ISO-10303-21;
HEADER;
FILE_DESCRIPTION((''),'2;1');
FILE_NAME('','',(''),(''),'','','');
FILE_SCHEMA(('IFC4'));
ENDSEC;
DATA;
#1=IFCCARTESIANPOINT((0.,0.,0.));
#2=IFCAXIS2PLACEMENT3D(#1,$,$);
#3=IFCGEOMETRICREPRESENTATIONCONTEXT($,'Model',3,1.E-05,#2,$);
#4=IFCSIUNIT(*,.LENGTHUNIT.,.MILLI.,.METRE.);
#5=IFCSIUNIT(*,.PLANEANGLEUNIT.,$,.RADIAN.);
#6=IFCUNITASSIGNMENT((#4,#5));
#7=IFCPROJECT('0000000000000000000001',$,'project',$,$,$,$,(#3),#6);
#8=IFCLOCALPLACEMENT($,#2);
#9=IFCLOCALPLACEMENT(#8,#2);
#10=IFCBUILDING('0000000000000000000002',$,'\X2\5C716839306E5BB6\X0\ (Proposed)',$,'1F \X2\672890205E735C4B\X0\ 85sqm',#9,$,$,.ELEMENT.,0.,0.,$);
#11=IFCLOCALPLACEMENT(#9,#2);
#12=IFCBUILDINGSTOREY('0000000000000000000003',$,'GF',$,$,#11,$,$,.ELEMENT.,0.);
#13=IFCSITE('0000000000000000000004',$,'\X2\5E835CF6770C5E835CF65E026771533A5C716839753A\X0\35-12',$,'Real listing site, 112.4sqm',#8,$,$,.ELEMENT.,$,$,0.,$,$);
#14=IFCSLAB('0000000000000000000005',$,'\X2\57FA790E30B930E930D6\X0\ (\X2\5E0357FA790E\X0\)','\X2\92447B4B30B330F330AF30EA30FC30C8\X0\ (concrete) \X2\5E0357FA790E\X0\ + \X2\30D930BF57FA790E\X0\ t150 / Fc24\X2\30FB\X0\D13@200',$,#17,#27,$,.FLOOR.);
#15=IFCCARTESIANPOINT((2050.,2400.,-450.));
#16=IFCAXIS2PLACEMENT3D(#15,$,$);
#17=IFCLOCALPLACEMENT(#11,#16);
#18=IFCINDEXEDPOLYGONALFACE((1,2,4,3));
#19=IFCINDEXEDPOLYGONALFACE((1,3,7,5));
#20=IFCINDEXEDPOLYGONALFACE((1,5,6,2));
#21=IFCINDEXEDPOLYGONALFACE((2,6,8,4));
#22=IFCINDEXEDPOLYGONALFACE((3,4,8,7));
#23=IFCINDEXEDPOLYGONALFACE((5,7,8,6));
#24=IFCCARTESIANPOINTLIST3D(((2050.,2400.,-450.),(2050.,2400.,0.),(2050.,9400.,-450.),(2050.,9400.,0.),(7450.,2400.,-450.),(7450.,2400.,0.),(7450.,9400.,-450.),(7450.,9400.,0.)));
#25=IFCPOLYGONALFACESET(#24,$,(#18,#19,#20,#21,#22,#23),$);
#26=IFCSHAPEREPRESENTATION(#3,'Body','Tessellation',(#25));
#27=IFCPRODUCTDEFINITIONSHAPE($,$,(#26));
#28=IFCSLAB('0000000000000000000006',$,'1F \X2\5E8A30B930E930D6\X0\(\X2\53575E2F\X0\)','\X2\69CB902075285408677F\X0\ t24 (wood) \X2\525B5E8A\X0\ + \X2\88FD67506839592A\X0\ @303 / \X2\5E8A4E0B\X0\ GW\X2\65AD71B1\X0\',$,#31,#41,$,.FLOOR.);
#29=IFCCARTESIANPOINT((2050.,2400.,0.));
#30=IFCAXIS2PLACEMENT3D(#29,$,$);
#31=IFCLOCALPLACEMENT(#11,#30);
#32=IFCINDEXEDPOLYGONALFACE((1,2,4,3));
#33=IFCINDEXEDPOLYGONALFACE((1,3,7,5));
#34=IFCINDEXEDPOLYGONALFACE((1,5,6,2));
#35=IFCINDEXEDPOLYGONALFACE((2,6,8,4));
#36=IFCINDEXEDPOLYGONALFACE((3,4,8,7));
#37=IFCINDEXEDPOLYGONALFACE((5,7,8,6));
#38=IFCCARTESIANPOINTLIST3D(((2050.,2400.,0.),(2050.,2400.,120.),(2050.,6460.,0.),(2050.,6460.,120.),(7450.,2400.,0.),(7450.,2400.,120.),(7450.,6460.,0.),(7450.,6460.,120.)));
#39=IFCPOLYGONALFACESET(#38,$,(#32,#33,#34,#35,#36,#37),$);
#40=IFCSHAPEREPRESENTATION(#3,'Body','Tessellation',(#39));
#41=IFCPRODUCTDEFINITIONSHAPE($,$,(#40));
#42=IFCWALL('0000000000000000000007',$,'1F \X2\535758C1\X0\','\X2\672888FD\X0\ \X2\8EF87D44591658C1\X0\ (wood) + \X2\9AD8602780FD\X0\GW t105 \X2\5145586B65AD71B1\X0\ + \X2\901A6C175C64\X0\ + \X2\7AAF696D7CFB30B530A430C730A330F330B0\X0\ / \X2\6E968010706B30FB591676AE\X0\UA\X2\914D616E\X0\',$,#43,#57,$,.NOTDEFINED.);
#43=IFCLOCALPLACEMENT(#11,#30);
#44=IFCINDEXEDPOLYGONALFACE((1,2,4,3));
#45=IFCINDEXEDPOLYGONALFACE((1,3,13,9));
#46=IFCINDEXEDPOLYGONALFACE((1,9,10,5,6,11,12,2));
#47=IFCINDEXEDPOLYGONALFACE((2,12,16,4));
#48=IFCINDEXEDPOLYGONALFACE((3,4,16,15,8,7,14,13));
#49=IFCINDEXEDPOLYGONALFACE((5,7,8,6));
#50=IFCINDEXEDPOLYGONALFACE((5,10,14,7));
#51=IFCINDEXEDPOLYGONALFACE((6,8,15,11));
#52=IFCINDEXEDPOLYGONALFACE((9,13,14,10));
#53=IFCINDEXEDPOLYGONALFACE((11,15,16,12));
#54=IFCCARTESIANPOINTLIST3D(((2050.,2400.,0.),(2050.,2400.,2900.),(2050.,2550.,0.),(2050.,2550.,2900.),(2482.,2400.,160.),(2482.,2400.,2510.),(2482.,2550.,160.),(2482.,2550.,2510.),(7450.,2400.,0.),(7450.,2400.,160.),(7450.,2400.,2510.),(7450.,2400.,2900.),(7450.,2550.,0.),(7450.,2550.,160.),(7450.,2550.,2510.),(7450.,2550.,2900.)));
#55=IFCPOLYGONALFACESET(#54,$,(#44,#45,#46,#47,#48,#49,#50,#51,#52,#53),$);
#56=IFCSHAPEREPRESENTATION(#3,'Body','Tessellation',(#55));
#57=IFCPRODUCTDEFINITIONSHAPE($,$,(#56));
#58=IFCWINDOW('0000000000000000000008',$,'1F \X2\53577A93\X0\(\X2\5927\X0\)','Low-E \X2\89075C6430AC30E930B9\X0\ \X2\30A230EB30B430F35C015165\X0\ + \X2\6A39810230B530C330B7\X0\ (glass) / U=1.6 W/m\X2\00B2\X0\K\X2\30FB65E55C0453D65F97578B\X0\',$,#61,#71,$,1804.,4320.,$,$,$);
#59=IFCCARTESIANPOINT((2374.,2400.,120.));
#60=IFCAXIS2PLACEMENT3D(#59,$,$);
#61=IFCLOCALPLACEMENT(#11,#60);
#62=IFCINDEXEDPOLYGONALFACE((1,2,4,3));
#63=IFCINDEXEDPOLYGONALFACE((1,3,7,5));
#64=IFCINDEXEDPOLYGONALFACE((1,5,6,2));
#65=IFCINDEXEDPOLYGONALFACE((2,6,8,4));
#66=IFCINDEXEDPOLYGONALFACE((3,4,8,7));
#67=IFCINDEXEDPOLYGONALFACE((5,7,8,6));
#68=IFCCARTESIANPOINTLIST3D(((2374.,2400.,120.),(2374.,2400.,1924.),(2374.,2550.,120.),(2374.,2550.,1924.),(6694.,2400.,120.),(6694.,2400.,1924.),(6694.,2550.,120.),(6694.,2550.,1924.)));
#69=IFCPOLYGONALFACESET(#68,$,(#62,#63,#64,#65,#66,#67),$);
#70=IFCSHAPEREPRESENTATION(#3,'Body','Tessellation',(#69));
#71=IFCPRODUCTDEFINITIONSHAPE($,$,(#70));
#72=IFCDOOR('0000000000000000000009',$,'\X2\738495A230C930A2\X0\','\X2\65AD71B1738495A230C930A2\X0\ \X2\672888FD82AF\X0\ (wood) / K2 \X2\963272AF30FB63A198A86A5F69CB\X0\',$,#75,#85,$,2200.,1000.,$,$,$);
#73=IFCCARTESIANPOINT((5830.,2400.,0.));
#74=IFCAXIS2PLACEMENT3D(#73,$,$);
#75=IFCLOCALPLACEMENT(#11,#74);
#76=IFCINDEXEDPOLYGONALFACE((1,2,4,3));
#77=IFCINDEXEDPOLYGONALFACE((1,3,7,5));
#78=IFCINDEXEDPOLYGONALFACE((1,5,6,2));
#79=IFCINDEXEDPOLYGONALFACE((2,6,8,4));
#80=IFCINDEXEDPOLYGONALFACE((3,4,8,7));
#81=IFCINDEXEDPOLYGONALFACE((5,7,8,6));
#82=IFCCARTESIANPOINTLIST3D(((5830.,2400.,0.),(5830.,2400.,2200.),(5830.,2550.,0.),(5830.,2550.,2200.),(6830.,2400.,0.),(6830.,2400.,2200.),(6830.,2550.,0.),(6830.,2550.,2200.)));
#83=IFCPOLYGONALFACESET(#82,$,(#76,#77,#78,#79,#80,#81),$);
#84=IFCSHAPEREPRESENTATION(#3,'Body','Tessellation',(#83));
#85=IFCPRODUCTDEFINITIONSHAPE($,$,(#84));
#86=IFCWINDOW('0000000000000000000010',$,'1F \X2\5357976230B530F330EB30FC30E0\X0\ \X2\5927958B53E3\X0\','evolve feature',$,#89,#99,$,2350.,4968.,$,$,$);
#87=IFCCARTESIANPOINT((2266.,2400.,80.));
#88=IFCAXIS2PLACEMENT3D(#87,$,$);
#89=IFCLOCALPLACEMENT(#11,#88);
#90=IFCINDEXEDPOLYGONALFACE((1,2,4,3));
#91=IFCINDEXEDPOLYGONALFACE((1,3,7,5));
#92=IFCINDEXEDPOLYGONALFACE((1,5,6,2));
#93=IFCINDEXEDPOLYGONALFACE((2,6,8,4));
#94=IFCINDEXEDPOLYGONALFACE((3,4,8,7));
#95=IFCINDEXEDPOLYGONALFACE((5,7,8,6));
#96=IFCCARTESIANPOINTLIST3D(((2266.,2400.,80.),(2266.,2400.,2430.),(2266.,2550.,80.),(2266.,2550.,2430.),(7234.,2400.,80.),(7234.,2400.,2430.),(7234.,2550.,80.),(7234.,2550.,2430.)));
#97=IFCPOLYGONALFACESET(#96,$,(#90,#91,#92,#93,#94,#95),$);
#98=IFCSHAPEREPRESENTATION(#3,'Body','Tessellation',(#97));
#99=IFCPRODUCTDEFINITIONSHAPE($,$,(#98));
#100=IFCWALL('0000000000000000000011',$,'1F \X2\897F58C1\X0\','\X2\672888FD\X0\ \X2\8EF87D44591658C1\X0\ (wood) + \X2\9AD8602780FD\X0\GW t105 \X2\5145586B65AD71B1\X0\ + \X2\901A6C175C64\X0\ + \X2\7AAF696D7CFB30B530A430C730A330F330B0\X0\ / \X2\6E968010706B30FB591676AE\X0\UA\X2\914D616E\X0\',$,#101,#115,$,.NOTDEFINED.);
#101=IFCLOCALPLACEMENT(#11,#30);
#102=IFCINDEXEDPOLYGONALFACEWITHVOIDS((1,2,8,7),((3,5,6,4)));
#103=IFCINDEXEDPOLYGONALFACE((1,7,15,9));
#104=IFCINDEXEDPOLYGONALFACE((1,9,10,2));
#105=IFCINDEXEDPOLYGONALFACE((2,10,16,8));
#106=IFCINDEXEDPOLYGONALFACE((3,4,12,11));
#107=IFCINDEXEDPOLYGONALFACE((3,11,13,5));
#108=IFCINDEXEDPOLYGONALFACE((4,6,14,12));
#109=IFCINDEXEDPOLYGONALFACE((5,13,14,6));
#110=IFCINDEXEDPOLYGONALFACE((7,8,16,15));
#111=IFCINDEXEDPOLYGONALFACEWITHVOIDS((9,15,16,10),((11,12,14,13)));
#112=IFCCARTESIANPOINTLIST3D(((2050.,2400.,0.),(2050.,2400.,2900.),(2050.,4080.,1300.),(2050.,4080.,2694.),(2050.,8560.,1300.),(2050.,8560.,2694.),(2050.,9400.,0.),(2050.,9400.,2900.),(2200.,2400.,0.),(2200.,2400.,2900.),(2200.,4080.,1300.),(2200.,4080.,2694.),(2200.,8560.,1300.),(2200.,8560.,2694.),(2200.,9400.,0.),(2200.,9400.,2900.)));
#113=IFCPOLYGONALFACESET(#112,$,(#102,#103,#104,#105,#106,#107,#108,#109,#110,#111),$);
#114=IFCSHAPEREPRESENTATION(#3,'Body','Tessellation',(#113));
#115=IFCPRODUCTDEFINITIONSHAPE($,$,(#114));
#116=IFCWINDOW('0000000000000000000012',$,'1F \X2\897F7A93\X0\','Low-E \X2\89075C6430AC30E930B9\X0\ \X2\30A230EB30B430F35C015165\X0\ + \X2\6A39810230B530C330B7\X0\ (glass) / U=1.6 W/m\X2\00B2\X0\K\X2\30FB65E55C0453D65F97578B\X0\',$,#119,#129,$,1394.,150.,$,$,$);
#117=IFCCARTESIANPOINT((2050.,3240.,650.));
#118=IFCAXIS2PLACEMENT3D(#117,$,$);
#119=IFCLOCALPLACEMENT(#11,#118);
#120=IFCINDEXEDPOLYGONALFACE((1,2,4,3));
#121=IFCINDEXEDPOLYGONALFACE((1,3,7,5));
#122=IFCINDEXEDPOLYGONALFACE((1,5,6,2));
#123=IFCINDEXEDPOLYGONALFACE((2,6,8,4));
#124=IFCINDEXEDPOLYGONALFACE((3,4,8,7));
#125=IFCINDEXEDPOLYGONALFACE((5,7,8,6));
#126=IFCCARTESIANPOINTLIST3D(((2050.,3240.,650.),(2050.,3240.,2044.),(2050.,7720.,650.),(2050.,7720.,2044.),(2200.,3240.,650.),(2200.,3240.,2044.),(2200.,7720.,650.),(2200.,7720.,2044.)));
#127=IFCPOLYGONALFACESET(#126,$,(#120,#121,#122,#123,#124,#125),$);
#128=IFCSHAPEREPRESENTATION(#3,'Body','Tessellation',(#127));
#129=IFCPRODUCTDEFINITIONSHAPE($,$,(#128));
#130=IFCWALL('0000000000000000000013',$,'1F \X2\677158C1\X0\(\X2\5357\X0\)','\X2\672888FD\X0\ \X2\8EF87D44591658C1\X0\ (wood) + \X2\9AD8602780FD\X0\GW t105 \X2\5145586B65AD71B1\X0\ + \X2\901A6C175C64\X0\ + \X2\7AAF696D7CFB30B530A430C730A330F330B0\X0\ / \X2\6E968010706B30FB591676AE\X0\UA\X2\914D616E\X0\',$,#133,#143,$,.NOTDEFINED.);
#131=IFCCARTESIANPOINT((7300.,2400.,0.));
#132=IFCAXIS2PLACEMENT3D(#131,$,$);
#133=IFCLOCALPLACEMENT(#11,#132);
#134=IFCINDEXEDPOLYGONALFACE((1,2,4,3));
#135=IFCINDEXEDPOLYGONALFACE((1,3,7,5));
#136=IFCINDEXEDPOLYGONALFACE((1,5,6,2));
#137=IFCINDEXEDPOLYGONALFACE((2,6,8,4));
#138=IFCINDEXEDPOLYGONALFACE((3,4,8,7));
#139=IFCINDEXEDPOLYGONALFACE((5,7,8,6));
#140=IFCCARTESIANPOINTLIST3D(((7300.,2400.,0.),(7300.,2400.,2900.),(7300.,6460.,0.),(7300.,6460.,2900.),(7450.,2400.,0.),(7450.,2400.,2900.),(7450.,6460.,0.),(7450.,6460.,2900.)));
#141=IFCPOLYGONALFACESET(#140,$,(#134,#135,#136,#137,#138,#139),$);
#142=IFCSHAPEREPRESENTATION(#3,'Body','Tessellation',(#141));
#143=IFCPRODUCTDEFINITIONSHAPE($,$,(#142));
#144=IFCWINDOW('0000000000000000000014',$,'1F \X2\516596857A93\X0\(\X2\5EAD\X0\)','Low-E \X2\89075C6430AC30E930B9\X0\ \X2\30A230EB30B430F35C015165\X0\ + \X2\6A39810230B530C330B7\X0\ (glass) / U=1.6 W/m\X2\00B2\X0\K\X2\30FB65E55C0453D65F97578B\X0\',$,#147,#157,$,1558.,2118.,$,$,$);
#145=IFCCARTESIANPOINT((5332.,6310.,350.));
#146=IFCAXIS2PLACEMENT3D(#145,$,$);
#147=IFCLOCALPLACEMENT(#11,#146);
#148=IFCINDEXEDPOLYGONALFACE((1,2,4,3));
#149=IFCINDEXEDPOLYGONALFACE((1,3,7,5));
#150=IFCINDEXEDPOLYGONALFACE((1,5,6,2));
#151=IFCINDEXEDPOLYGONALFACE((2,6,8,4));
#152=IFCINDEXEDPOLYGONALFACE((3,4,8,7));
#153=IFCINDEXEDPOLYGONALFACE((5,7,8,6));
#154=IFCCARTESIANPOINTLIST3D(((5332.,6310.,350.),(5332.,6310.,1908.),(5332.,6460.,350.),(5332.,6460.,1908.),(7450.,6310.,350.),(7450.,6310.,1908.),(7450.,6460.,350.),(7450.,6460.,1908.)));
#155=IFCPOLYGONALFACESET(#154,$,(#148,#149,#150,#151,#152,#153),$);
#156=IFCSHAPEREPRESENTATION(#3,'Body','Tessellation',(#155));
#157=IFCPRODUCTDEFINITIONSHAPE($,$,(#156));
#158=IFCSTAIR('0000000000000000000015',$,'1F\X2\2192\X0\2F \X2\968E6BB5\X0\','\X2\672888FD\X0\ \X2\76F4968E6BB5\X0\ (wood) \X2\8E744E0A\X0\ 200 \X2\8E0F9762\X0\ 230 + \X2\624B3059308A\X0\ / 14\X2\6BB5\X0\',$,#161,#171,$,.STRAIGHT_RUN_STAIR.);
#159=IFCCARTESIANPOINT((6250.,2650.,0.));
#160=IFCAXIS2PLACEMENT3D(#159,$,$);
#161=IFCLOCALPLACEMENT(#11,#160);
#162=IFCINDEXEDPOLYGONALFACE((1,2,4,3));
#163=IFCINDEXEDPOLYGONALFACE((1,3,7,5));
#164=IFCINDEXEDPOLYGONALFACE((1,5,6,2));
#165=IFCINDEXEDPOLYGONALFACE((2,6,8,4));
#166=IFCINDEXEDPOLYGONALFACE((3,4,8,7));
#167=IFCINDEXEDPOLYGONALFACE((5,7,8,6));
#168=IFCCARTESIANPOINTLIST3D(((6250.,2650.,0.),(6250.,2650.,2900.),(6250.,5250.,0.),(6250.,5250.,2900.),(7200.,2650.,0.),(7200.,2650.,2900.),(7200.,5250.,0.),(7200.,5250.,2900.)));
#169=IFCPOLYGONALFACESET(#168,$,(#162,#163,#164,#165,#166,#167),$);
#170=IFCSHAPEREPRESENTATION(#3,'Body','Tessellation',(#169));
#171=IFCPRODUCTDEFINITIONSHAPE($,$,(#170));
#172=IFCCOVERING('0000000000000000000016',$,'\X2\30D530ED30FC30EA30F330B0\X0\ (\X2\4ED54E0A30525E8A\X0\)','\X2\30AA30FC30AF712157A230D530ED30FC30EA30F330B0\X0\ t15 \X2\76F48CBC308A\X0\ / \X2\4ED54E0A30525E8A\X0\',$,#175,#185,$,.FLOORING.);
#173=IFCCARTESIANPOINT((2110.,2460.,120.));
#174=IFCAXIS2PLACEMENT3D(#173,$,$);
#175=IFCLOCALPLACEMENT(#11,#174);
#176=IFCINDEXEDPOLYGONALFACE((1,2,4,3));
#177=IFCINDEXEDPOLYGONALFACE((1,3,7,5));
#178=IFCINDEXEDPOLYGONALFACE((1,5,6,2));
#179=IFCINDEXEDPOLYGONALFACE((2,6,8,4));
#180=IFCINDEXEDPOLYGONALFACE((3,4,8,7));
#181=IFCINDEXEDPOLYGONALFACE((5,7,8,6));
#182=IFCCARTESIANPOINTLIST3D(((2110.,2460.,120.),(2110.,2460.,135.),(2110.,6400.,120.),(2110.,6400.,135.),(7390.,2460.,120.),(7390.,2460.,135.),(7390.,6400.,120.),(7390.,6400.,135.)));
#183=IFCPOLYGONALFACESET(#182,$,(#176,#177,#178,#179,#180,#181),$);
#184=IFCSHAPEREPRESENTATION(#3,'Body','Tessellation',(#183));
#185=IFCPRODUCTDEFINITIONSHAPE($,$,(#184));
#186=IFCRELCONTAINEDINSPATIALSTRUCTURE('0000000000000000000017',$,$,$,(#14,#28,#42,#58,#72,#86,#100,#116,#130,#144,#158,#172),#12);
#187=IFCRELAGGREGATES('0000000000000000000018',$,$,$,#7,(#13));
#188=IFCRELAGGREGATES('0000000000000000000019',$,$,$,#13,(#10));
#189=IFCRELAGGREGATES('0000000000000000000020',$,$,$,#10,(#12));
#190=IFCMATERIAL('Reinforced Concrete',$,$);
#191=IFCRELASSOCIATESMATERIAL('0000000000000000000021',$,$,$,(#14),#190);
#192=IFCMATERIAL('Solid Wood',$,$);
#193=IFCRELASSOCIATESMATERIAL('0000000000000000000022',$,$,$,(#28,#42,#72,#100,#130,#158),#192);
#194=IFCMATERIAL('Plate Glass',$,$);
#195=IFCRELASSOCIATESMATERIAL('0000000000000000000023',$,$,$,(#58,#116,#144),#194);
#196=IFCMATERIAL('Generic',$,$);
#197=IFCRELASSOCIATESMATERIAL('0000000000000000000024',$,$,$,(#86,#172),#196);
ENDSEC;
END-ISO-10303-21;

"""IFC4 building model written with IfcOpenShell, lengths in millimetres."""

from ifc_helpers import new_model, si_unit, frame, frame_2d, origin, place, context, project, spatial, rectangle, extrude, material, element, fill, save


model = new_model("IFC4")

# Units and contexts
model_context = context("Model", 3, precision=1e-05, world=origin())
ifc_project = project(units=[si_unit("LENGTHUNIT", "METRE", prefix="MILLI"), si_unit("PLANEANGLEUNIT", "RADIAN")], contexts=[model_context])

# Site, building, storey
site_placement = place(None, origin())
site = spatial("IfcSite", under=ifc_project, at=site_placement, Name="広島県広島市東区山根町35-12", ObjectType="Real listing site, 112.4sqm", CompositionType="ELEMENT", RefElevation=0.0)
building_placement = place(site_placement, origin())
building = spatial("IfcBuilding", under=site, at=building_placement, Name="山根の家 (Proposed)", ObjectType="1F 木造平屋 85sqm", CompositionType="ELEMENT", ElevationOfRefHeight=0.0, ElevationOfTerrain=0.0)
storey_placement = place(building_placement, origin())
storey = spatial("IfcBuildingStorey", under=building, at=storey_placement, Name="GF", CompositionType="ELEMENT", Elevation=0.0)

# Slabs
ifc_material_1 = material(Name="Reinforced Concrete")
slab_1_placement = place(storey_placement, frame((2050.0, 2400.0, -450.0)))
element("IfcSlab", 1, at=slab_1_placement, inside=storey, material=ifc_material_1, Name="基礎スラブ (布基礎)", Description="鉄筋コンクリート (concrete) 布基礎 + ベタ基礎 t150 / Fc24・D13@200", PredefinedType="FLOOR", context=model_context, shape_type="SweptSolid", body=[
    extrude(rectangle(XDim=5400.0, YDim=7000.0, at=frame_2d((2700.0, 3500.0))), frame((2050.0, 2400.0, -450.0)), (0.0, 0.0, 1.0), 450.0),
])
ifc_material_2 = material(Name="Solid Wood")
slab_2_placement = place(storey_placement, frame((2050.0, 2400.0, 0.0)))
element("IfcSlab", 2, at=slab_2_placement, inside=storey, material=ifc_material_2, Name="1F 床スラブ(南帯)", Description="構造用合板 t24 (wood) 剛床 + 製材根太 @303 / 床下 GW断熱", PredefinedType="FLOOR", context=model_context, shape_type="SweptSolid", body=[
    extrude(rectangle(XDim=5400.0, YDim=4060.0, at=frame_2d((2700.0, 2030.0))), frame((2050.0, 2400.0, 0.0)), (0.0, 0.0, 1.0), 120.0),
])

# Wall, openings, windows, door
wall_1_placement = place(storey_placement, frame((2050.0, 2400.0, 0.0)))
wall_1 = element("IfcWall", 3, at=wall_1_placement, inside=storey, material=ifc_material_2, Name="1F 南壁", Description="木製 軸組外壁 (wood) + 高性能GW t105 充填断熱 + 通気層 + 窯業系サイディング / 準耐火・外皮UA配慮", PredefinedType="NOTDEFINED", context=model_context, shape_type="SweptSolid", body=[
    extrude(rectangle(XDim=5400.0, YDim=150.0, at=frame_2d((2700.0, 75.0))), frame((2050.0, 2400.0, 0.0)), (0.0, 0.0, 1.0), 2900.0),
])
opening_1_placement = place(storey_placement, frame((2374.0, 2400.0, 120.0)))
opening_1 = element("IfcOpeningElement", 4, at=opening_1_placement, cuts=wall_1, PredefinedType="NOTDEFINED", context=model_context, shape_type="SweptSolid", body=[
    extrude(rectangle(XDim=4320.0, YDim=150.0, at=frame_2d((2160.0, 75.0))), frame((2374.0, 2400.0, 120.0)), (0.0, 0.0, 1.0), 1804.0),
])
opening_2_placement = place(storey_placement, frame((5830.0, 2400.0, 0.0)))
opening_2 = element("IfcOpeningElement", 5, at=opening_2_placement, cuts=wall_1, PredefinedType="NOTDEFINED", context=model_context, shape_type="SweptSolid", body=[
    extrude(rectangle(XDim=1000.0, YDim=150.0, at=frame_2d((500.0, 75.0))), frame((5830.0, 2400.0, 0.0)), (0.0, 0.0, 1.0), 2200.0),
])
opening_3_placement = place(storey_placement, frame((2266.0, 2400.0, 80.0)))
opening_3 = element("IfcOpeningElement", 6, at=opening_3_placement, cuts=wall_1, PredefinedType="NOTDEFINED", context=model_context, shape_type="SweptSolid", body=[
    extrude(rectangle(XDim=4968.0, YDim=150.0, at=frame_2d((2484.0, 75.0))), frame((2266.0, 2400.0, 80.0)), (0.0, 0.0, 1.0), 2350.0),
])
ifc_material_3 = material(Name="Plate Glass")
window_1_placement = place(storey_placement, frame((2374.0, 2400.0, 120.0)))
window_1 = element("IfcWindow", 7, at=window_1_placement, inside=storey, material=ifc_material_3, Name="1F 南窓(大)", Description="Low-E 複層ガラス アルゴン封入 + 樹脂サッシ (glass) / U=1.6 W/m²K・日射取得型", OverallHeight=1804.0, OverallWidth=4320.0, context=model_context, shape_type="SweptSolid", body=[
    extrude(rectangle(XDim=4320.0, YDim=150.0, at=frame_2d((2160.0, 75.0))), frame((2374.0, 2400.0, 120.0)), (0.0, 0.0, 1.0), 1804.0),
])
fill(opening_1, window_1)
door_1_placement = place(storey_placement, frame((5830.0, 2400.0, 0.0)))
door_1 = element("IfcDoor", 8, at=door_1_placement, inside=storey, material=ifc_material_2, Name="玄関ドア", Description="断熱玄関ドア 木製芯 (wood) / K2 防犯・採風機構", OverallHeight=2200.0, OverallWidth=1000.0, context=model_context, shape_type="SweptSolid", body=[
    extrude(rectangle(XDim=1000.0, YDim=150.0, at=frame_2d((500.0, 75.0))), frame((5830.0, 2400.0, 0.0)), (0.0, 0.0, 1.0), 2200.0),
])
fill(opening_2, door_1)
ifc_material_4 = material(Name="Generic")
window_2_placement = place(storey_placement, frame((2266.0, 2400.0, 80.0)))
window_2 = element("IfcWindow", 9, at=window_2_placement, inside=storey, material=ifc_material_4, Name="1F 南面サンルーム 大開口", Description="evolve feature", OverallHeight=2350.0, OverallWidth=4968.0, context=model_context, shape_type="SweptSolid", body=[
    extrude(rectangle(XDim=4968.0, YDim=150.0, at=frame_2d((2484.0, 75.0))), frame((2266.0, 2400.0, 80.0)), (0.0, 0.0, 1.0), 2350.0),
])
fill(opening_3, window_2)

# Walls, openings, windows
wall_2_placement = place(storey_placement, frame((2050.0, 2400.0, 0.0)))
wall_2 = element("IfcWall", 10, at=wall_2_placement, inside=storey, material=ifc_material_2, Name="1F 西壁", Description="木製 軸組外壁 (wood) + 高性能GW t105 充填断熱 + 通気層 + 窯業系サイディング / 準耐火・外皮UA配慮", PredefinedType="NOTDEFINED", context=model_context, shape_type="SweptSolid", body=[
    extrude(rectangle(XDim=150.0, YDim=7000.0, at=frame_2d((75.0, 3500.0))), frame((2050.0, 2400.0, 0.0)), (0.0, 0.0, 1.0), 2900.0),
])
opening_4_placement = place(storey_placement, frame((2050.0, 3240.0, 650.0)))
opening_4 = element("IfcOpeningElement", 11, at=opening_4_placement, cuts=wall_2, PredefinedType="NOTDEFINED", context=model_context, shape_type="SweptSolid", body=[
    extrude(rectangle(XDim=150.0, YDim=4480.0, at=frame_2d((75.0, 2240.0))), frame((2050.0, 3240.0, 650.0)), (0.0, 0.0, 1.0), 1394.0),
])
window_3_placement = place(storey_placement, frame((2050.0, 3240.0, 650.0)))
window_3 = element("IfcWindow", 12, at=window_3_placement, inside=storey, material=ifc_material_3, Name="1F 西窓", Description="Low-E 複層ガラス アルゴン封入 + 樹脂サッシ (glass) / U=1.6 W/m²K・日射取得型", OverallHeight=1394.0, OverallWidth=150.0, context=model_context, shape_type="SweptSolid", body=[
    extrude(rectangle(XDim=150.0, YDim=4480.0, at=frame_2d((75.0, 2240.0))), frame((2050.0, 3240.0, 650.0)), (0.0, 0.0, 1.0), 1394.0),
])
fill(opening_4, window_3)
wall_3_placement = place(storey_placement, frame((7300.0, 2400.0, 0.0)))
wall_3 = element("IfcWall", 13, at=wall_3_placement, inside=storey, material=ifc_material_2, Name="1F 東壁(南)", Description="木製 軸組外壁 (wood) + 高性能GW t105 充填断熱 + 通気層 + 窯業系サイディング / 準耐火・外皮UA配慮", PredefinedType="NOTDEFINED", context=model_context, shape_type="SweptSolid", body=[
    extrude(rectangle(XDim=150.0, YDim=4060.0, at=frame_2d((75.0, 2030.0))), frame((7300.0, 2400.0, 0.0)), (0.0, 0.0, 1.0), 2900.0),
])
opening_5_placement = place(storey_placement, frame((5332.0, 6310.0, 350.0)))
opening_5 = element("IfcOpeningElement", 14, at=opening_5_placement, cuts=wall_3, PredefinedType="NOTDEFINED", context=model_context, shape_type="SweptSolid", body=[
    extrude(rectangle(XDim=2118.0, YDim=150.0, at=frame_2d((1059.0, 75.0))), frame((5332.0, 6310.0, 350.0)), (0.0, 0.0, 1.0), 1558.0),
])
window_4_placement = place(storey_placement, frame((5332.0, 6310.0, 350.0)))
window_4 = element("IfcWindow", 15, at=window_4_placement, inside=storey, material=ifc_material_3, Name="1F 入隅窓(庭)", Description="Low-E 複層ガラス アルゴン封入 + 樹脂サッシ (glass) / U=1.6 W/m²K・日射取得型", OverallHeight=1558.0, OverallWidth=2118.0, context=model_context, shape_type="SweptSolid", body=[
    extrude(rectangle(XDim=2118.0, YDim=150.0, at=frame_2d((1059.0, 75.0))), frame((5332.0, 6310.0, 350.0)), (0.0, 0.0, 1.0), 1558.0),
])
fill(opening_5, window_4)

# Stair
stair_placement = place(storey_placement, frame((6250.0, 2650.0, 0.0)))
element("IfcStair", 16, at=stair_placement, inside=storey, material=ifc_material_2, Name="1F→2F 階段", Description="木製 直階段 (wood) 蹴上 200 踏面 230 + 手すり / 14段", PredefinedType="STRAIGHT_RUN_STAIR", context=model_context, shape_type="SweptSolid", body=[
    extrude(rectangle(XDim=950.0, YDim=2600.0, at=frame_2d((475.0, 1300.0))), frame((6250.0, 2650.0, 0.0)), (0.0, 0.0, 1.0), 2900.0),
])

# Covering
covering_placement = place(storey_placement, frame((2110.0, 2460.0, 120.0)))
element("IfcCovering", 17, at=covering_placement, inside=storey, material=ifc_material_4, Name="フローリング (仕上げ床)", Description="オーク無垢フローリング t15 直貼り / 仕上げ床", PredefinedType="FLOORING", context=model_context, shape_type="SweptSolid", body=[
    extrude(rectangle(XDim=5280.0, YDim=3940.0, at=frame_2d((2640.0, 1970.0))), frame((2110.0, 2460.0, 120.0)), (0.0, 0.0, 1.0), 15.0),
])

save(model, "model.ifc")
